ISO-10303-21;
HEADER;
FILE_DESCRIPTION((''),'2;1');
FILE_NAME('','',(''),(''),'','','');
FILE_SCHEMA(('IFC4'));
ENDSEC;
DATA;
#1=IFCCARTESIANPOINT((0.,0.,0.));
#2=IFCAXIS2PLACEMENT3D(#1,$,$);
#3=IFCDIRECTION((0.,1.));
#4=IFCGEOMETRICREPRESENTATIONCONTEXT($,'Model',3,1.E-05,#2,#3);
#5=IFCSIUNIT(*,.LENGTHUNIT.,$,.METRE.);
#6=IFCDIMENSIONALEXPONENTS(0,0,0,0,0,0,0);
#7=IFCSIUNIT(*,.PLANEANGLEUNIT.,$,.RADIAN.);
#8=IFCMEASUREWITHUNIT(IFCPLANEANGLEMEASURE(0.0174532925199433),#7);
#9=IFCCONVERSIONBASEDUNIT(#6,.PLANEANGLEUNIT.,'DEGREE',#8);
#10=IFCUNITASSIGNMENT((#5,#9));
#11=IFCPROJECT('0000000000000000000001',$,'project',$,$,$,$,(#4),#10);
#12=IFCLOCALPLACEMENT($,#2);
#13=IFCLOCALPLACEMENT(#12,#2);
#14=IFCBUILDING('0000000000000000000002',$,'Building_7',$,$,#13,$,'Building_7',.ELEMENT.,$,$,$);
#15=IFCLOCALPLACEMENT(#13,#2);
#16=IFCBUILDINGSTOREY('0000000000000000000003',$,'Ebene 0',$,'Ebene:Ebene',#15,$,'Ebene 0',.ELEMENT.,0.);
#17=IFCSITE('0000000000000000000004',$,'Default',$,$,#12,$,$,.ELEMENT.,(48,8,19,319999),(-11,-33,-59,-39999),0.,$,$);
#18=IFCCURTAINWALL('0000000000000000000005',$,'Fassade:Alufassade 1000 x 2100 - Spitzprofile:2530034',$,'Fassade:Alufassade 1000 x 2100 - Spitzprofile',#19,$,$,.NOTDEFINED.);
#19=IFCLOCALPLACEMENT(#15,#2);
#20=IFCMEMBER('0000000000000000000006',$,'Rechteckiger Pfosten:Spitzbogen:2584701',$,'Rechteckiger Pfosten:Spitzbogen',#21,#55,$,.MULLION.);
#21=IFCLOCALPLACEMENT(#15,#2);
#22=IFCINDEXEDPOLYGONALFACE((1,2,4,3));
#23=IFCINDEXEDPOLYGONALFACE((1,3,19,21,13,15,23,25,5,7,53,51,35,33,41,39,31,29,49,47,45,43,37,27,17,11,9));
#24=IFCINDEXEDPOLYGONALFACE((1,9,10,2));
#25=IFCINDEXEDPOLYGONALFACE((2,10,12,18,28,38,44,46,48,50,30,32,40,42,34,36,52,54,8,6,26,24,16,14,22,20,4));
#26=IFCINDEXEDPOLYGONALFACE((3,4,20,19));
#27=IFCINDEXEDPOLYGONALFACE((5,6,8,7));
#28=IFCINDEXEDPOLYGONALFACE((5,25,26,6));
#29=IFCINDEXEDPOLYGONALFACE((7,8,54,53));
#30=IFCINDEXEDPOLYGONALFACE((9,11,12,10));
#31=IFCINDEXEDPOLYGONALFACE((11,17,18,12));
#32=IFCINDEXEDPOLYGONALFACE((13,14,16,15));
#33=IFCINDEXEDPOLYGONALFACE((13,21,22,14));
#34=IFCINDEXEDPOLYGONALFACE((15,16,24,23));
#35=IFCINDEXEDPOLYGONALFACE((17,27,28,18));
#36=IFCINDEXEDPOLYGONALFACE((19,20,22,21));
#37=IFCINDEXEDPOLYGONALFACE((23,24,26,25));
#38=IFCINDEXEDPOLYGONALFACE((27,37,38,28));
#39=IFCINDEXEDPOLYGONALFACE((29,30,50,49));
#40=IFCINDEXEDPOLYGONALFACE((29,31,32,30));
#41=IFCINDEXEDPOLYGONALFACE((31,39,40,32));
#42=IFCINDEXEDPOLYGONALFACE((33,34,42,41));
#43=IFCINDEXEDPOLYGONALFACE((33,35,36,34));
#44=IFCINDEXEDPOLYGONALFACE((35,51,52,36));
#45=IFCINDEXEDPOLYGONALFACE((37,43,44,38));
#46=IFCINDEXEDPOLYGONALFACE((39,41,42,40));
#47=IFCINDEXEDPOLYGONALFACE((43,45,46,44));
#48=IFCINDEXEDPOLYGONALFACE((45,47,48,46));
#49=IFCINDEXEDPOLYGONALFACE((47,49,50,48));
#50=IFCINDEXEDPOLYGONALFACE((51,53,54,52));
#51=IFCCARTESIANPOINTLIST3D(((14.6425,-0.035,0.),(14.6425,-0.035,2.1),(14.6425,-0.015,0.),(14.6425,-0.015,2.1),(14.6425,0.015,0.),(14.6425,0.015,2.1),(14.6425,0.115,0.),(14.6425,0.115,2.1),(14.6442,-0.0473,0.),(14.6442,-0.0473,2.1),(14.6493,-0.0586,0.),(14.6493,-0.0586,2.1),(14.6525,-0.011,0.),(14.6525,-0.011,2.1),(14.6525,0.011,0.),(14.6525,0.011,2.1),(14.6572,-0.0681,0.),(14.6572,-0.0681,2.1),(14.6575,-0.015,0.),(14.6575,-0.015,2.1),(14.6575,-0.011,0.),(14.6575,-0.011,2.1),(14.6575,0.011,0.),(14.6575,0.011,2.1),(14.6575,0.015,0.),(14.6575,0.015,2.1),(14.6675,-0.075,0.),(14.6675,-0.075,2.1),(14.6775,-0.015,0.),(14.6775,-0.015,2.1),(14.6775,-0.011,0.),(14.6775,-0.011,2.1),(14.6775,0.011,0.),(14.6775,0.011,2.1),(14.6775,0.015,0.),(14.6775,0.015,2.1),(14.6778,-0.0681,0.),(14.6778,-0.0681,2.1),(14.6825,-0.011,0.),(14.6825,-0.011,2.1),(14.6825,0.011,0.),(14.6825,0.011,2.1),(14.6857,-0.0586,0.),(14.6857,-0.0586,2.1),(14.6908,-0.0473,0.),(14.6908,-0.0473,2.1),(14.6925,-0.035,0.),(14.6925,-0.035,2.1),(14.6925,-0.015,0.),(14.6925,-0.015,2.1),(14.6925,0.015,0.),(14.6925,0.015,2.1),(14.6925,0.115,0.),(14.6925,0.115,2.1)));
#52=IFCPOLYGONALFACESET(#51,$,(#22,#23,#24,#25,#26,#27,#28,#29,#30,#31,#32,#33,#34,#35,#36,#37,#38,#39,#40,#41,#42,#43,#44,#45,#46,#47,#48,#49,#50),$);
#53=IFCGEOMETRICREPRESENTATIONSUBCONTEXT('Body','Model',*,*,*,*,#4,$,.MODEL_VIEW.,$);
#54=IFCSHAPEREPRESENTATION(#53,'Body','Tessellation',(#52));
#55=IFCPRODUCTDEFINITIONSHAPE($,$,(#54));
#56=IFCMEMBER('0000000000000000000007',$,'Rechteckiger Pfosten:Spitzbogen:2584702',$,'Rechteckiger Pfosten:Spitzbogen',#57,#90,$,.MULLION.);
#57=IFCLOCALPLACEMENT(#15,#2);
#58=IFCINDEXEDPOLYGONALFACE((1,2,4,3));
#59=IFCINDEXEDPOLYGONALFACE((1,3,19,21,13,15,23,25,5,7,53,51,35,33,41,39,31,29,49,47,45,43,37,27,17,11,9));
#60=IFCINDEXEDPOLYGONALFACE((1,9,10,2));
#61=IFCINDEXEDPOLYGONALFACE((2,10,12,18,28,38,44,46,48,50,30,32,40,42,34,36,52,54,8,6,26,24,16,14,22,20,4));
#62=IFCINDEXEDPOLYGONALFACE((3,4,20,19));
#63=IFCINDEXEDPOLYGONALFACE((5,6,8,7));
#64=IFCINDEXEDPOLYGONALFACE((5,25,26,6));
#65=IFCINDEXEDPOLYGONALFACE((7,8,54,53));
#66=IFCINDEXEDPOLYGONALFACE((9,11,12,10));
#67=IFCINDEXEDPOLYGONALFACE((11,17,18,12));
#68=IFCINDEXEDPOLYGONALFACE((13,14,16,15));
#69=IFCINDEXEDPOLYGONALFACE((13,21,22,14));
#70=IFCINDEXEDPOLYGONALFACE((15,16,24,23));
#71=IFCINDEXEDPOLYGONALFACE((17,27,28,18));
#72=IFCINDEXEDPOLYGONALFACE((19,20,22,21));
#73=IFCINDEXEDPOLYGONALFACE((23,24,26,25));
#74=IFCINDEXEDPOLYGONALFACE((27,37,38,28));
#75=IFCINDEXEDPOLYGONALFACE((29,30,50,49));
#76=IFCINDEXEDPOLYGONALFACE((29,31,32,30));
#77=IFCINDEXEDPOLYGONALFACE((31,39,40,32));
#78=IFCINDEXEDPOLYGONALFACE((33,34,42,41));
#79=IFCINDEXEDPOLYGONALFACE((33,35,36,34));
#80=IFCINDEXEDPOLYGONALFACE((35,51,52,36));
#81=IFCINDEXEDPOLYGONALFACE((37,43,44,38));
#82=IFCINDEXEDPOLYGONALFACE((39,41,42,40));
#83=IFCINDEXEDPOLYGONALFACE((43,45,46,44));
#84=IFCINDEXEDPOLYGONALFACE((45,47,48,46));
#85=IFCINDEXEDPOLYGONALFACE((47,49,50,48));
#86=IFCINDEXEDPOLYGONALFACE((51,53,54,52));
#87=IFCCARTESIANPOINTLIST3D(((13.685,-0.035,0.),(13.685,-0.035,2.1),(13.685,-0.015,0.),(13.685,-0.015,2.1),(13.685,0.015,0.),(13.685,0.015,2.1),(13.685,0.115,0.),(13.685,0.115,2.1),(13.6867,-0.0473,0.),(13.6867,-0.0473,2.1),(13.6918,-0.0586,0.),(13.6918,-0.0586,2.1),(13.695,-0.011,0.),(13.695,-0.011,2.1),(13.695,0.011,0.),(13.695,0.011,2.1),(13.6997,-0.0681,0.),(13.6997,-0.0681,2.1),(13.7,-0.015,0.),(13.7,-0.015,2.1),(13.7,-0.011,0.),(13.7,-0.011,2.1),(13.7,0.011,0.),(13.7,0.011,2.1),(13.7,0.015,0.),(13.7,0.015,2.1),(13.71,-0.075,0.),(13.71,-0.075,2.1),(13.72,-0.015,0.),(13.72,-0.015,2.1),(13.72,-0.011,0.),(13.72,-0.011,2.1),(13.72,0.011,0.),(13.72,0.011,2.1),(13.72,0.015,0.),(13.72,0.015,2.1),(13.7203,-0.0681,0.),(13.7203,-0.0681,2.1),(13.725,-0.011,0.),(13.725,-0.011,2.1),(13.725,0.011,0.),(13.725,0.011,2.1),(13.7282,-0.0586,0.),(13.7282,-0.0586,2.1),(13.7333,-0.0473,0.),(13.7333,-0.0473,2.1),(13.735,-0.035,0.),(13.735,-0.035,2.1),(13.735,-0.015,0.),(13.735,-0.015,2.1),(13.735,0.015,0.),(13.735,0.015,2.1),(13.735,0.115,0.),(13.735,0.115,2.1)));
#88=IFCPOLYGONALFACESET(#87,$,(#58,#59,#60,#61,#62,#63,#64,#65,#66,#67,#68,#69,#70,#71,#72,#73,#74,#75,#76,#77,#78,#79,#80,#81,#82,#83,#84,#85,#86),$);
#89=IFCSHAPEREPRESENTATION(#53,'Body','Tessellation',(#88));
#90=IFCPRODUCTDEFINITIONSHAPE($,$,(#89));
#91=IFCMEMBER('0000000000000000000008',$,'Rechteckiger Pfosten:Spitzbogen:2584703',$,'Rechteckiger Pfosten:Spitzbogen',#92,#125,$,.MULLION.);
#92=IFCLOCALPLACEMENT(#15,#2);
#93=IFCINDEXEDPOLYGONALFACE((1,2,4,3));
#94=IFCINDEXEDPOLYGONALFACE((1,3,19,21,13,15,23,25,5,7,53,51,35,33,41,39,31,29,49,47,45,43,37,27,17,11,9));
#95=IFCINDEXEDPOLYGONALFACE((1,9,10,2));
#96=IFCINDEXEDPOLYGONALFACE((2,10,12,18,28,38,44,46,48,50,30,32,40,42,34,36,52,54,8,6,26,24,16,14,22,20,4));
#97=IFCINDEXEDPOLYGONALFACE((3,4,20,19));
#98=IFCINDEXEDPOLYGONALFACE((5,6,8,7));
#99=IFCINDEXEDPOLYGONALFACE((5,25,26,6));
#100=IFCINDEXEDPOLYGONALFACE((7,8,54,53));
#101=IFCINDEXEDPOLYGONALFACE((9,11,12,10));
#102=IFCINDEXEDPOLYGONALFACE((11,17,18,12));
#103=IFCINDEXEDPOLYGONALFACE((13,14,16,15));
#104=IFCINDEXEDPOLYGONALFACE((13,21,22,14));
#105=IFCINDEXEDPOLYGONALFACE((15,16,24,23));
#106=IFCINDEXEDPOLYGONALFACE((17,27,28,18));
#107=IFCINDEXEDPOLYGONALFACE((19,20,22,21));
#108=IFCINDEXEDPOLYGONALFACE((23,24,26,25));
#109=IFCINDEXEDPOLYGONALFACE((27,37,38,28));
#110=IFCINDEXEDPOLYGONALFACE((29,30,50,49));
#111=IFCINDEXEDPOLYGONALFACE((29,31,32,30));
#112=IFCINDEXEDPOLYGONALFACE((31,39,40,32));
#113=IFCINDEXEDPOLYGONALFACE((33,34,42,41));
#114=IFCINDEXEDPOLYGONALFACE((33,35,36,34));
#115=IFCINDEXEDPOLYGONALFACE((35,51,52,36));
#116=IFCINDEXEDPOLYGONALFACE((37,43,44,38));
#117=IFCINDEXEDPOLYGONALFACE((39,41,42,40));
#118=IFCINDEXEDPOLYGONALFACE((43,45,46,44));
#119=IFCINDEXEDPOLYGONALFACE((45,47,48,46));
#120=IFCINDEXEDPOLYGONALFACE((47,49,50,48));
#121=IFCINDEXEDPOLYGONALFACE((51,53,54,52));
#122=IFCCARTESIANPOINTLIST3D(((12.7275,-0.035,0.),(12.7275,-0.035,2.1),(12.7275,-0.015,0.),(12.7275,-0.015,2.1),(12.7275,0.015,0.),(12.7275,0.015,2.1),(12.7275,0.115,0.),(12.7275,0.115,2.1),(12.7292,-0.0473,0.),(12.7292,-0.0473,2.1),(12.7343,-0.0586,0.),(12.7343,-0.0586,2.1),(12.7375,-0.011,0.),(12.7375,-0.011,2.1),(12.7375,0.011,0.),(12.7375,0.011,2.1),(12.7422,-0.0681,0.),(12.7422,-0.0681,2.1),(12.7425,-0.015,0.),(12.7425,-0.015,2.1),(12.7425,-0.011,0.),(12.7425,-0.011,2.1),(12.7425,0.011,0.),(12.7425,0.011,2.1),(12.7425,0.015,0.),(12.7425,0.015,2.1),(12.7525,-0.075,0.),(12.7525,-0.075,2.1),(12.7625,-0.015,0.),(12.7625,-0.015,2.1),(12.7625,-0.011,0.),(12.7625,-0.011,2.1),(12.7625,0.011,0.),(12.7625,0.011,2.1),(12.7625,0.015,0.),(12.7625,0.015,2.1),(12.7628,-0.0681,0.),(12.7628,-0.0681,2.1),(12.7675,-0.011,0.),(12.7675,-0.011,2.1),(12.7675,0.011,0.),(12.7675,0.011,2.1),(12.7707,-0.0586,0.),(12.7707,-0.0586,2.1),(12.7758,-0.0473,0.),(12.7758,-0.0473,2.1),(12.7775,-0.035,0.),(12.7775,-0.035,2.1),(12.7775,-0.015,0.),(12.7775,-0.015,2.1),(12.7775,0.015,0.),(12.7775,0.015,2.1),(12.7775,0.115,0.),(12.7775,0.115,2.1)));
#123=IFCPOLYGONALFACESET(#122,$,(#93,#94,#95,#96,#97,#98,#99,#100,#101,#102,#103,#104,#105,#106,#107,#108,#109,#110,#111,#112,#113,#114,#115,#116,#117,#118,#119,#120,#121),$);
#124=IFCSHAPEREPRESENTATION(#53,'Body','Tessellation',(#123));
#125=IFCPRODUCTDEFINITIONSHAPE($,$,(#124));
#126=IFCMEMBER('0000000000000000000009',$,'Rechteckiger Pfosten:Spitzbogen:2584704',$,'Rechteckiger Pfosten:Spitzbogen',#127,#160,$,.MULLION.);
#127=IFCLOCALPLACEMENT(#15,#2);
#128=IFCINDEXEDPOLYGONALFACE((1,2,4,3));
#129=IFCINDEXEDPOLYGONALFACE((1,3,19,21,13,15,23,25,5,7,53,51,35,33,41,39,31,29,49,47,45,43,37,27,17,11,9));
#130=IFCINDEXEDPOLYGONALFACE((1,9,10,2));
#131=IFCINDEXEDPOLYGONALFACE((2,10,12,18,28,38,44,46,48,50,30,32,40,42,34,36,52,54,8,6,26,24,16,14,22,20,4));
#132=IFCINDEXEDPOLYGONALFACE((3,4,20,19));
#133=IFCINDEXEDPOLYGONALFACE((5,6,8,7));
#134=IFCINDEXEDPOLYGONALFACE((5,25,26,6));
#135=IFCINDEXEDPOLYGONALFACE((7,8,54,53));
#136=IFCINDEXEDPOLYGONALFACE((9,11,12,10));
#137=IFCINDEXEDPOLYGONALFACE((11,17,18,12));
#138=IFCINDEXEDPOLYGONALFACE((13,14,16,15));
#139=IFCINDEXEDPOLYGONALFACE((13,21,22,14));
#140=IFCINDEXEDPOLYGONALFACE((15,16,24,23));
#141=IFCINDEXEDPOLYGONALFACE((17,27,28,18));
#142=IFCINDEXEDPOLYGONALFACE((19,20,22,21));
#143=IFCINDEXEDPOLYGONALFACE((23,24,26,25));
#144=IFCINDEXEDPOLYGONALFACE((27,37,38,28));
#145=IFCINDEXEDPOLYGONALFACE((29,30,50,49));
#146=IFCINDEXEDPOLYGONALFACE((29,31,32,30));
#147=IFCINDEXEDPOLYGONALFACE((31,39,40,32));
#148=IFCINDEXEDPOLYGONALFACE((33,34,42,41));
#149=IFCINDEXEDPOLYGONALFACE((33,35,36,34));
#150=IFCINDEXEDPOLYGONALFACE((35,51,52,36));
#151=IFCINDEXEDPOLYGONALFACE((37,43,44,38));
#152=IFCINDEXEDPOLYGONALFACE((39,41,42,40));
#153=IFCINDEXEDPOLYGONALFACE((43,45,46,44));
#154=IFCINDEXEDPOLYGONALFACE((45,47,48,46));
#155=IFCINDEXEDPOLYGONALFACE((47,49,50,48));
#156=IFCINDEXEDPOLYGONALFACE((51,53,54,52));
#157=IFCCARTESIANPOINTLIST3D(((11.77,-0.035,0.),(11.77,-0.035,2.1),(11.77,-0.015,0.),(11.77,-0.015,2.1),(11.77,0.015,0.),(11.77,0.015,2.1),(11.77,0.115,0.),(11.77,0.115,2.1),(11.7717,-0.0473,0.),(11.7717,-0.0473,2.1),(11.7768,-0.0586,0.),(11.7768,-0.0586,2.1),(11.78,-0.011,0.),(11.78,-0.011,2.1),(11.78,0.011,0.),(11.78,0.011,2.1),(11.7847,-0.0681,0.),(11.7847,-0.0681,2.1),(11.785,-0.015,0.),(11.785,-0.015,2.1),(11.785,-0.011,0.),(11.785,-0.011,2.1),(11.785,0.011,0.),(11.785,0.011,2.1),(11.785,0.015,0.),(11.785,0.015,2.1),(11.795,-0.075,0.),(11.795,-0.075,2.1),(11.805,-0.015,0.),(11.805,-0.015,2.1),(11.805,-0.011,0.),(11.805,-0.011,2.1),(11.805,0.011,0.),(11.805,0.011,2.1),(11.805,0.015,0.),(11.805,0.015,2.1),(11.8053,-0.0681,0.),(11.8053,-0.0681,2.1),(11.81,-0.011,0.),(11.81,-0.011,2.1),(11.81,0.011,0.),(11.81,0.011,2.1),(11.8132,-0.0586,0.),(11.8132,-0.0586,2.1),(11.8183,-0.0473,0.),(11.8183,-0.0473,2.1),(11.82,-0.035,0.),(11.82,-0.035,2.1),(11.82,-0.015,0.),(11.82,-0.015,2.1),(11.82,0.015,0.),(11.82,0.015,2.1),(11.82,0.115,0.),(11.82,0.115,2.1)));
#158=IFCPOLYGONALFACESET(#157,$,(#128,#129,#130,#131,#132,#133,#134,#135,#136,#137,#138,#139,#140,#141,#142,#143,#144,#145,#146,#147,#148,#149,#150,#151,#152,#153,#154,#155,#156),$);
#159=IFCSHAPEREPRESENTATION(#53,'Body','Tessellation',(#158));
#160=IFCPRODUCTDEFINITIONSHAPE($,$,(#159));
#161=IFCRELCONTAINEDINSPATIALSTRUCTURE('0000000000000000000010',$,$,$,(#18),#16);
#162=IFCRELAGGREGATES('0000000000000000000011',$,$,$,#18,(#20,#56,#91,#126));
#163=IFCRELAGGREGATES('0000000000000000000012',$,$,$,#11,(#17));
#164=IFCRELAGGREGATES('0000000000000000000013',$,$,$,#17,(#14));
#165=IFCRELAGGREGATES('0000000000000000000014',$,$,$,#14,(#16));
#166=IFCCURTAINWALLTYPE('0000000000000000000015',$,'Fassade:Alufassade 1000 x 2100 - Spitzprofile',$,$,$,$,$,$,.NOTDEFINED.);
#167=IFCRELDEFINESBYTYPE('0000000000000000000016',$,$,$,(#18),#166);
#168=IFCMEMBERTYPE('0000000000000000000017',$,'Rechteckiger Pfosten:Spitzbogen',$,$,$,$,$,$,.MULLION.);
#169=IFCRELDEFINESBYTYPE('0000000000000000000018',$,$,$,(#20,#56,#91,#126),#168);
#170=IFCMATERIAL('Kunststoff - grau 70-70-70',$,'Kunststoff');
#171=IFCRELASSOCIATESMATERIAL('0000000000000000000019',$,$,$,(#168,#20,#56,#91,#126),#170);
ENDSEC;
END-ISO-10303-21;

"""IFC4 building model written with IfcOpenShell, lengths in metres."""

from ifc_helpers import new_model, entity, si_unit, converted_unit, direction, frame, origin, place, context, subcontext, project, spatial, line, arc, indexed_curve, outline, extrude, source, transform, mapped, material, type_object, type_shapes, element, aggregate, save


model = new_model("IFC4")

# Units and contexts
model_context = context("Model", 3, precision=1e-05, world=origin(), true_north=direction((0.0, 1.0)))
body_context = subcontext(model_context, "Body", "Model", "MODEL_VIEW")
ifc_project = project(units=[si_unit("LENGTHUNIT", "METRE"), converted_unit("PLANEANGLEUNIT", "DEGREE", entity("IfcPlaneAngleMeasure", 0.0174532925199433), si_unit("PLANEANGLEUNIT", "RADIAN"), dimensions=[0, 0, 0, 0, 0, 0, 0])], contexts=[model_context])

# Site, building, storey
site_placement = place(None, origin())
site = spatial("IfcSite", under=ifc_project, at=site_placement, Name="Default", CompositionType="ELEMENT", RefLatitude=(48, 8, 19, 319999), RefLongitude=(-11, -33, -59, -39999), RefElevation=0.0)
building_placement = place(site_placement, origin())
building = spatial("IfcBuilding", under=site, at=building_placement, Name="Building_7", LongName="Building_7", CompositionType="ELEMENT")
storey_placement = place(building_placement, origin())
storey = spatial("IfcBuildingStorey", under=building, at=storey_placement, Name="Ebene 0", ObjectType="Ebene:Ebene", LongName="Ebene 0", CompositionType="ELEMENT", Elevation=0.0)

# Curtain wall, members
curtain_wall_type = type_object("IfcCurtainWallType", Name="Fassade:Alufassade 1000 x 2100 - Spitzprofile", PredefinedType="NOTDEFINED")
curtain_wall_placement = place(storey_placement, origin())
curtain_wall = element("IfcCurtainWall", 1, at=curtain_wall_placement, inside=storey, type_object=curtain_wall_type, Name="Fassade:Alufassade 1000 x 2100 - Spitzprofile:2530034", ObjectType="Fassade:Alufassade 1000 x 2100 - Spitzprofile", PredefinedType="NOTDEFINED")
ifc_material = material(Name="Kunststoff - grau 70-70-70", Category="Kunststoff")
member_type_1 = type_object("IfcMemberType", Name="Rechteckiger Pfosten:Spitzbogen", PredefinedType="MULLION", material=ifc_material)
shared_shape_1 = source(origin(), body_context, "Body", "SweptSolid", [
    extrude(outline(indexed_curve([(-0.111, -0.025), (-0.011, -0.025), (-0.011, -0.01), (-0.007, -0.01), (-0.007, -0.015), (0.015, -0.015), (0.015, -0.01), (0.019, -0.01), (0.019, -0.025), (0.039, -0.025), (0.0626, -0.0182), (0.079, 0.0), (0.0626, 0.0182), (0.039, 0.025), (0.019, 0.025), (0.019, 0.01), (0.015, 0.01), (0.015, 0.015), (-0.007, 0.015), (-0.007, 0.01), (-0.011, 0.01), (-0.011, 0.025), (-0.111, 0.025)], segments=[line(1, 2, 3, 4, 5, 6, 7, 8, 9, 10), arc(10, 11, 12), arc(12, 13, 14), line(14, 15, 16, 17, 18, 19, 20, 21, 22, 23, 1)], self_intersect=False)), frame((0.0, 0.004, -2.1), z_axis=(0.0, 0.0, 1.0), x_axis=(0.0, -1.0, 0.0)), (0.0, 0.0, 1.0), 2.1),
])
type_shapes(member_type_1, [shared_shape_1])
member_1_placement = place(curtain_wall_placement, frame((14.6675, 0.0, 0.0), z_axis=(0.0, 0.0, -1.0), x_axis=(-1.0, 0.0, 0.0)))
member_1 = element("IfcMember", 2, at=member_1_placement, type_object=member_type_1, material=ifc_material, Name="Rechteckiger Pfosten:Spitzbogen:2584701", ObjectType="Rechteckiger Pfosten:Spitzbogen", PredefinedType="MULLION", context=body_context, shape_type="MappedRepresentation", body=[
    mapped(shared_shape_1, transform((0.0, 0.0, 0.0), scale=1.0)),
])
member_2_placement = place(curtain_wall_placement, frame((13.71, 0.0, 0.0), z_axis=(0.0, 0.0, -1.0), x_axis=(-1.0, 0.0, 0.0)))
member_2 = element("IfcMember", 3, at=member_2_placement, type_object=member_type_1, material=ifc_material, Name="Rechteckiger Pfosten:Spitzbogen:2584702", ObjectType="Rechteckiger Pfosten:Spitzbogen", PredefinedType="MULLION", context=body_context, shape_type="MappedRepresentation", body=[
    mapped(shared_shape_1, transform((0.0, 0.0, 0.0), scale=1.0)),
])
member_3_placement = place(curtain_wall_placement, frame((12.7525, 0.0, 0.0), z_axis=(0.0, 0.0, -1.0), x_axis=(-1.0, 0.0, 0.0)))
member_3 = element("IfcMember", 4, at=member_3_placement, type_object=member_type_1, material=ifc_material, Name="Rechteckiger Pfosten:Spitzbogen:2584703", ObjectType="Rechteckiger Pfosten:Spitzbogen", PredefinedType="MULLION", context=body_context, shape_type="MappedRepresentation", body=[
    mapped(shared_shape_1, transform((0.0, 0.0, 0.0), scale=1.0)),
])
member_4_placement = place(curtain_wall_placement, frame((11.795, 0.0, 0.0), z_axis=(0.0, 0.0, -1.0), x_axis=(-1.0, 0.0, 0.0)))
member_4 = element("IfcMember", 5, at=member_4_placement, type_object=member_type_1, material=ifc_material, Name="Rechteckiger Pfosten:Spitzbogen:2584704", ObjectType="Rechteckiger Pfosten:Spitzbogen", PredefinedType="MULLION", context=body_context, shape_type="MappedRepresentation", body=[
    mapped(shared_shape_1, transform((0.0, 0.0, 0.0), scale=1.0)),
])
aggregate(curtain_wall, [member_1, member_2, member_3, member_4])

save(model, "model.ifc")
